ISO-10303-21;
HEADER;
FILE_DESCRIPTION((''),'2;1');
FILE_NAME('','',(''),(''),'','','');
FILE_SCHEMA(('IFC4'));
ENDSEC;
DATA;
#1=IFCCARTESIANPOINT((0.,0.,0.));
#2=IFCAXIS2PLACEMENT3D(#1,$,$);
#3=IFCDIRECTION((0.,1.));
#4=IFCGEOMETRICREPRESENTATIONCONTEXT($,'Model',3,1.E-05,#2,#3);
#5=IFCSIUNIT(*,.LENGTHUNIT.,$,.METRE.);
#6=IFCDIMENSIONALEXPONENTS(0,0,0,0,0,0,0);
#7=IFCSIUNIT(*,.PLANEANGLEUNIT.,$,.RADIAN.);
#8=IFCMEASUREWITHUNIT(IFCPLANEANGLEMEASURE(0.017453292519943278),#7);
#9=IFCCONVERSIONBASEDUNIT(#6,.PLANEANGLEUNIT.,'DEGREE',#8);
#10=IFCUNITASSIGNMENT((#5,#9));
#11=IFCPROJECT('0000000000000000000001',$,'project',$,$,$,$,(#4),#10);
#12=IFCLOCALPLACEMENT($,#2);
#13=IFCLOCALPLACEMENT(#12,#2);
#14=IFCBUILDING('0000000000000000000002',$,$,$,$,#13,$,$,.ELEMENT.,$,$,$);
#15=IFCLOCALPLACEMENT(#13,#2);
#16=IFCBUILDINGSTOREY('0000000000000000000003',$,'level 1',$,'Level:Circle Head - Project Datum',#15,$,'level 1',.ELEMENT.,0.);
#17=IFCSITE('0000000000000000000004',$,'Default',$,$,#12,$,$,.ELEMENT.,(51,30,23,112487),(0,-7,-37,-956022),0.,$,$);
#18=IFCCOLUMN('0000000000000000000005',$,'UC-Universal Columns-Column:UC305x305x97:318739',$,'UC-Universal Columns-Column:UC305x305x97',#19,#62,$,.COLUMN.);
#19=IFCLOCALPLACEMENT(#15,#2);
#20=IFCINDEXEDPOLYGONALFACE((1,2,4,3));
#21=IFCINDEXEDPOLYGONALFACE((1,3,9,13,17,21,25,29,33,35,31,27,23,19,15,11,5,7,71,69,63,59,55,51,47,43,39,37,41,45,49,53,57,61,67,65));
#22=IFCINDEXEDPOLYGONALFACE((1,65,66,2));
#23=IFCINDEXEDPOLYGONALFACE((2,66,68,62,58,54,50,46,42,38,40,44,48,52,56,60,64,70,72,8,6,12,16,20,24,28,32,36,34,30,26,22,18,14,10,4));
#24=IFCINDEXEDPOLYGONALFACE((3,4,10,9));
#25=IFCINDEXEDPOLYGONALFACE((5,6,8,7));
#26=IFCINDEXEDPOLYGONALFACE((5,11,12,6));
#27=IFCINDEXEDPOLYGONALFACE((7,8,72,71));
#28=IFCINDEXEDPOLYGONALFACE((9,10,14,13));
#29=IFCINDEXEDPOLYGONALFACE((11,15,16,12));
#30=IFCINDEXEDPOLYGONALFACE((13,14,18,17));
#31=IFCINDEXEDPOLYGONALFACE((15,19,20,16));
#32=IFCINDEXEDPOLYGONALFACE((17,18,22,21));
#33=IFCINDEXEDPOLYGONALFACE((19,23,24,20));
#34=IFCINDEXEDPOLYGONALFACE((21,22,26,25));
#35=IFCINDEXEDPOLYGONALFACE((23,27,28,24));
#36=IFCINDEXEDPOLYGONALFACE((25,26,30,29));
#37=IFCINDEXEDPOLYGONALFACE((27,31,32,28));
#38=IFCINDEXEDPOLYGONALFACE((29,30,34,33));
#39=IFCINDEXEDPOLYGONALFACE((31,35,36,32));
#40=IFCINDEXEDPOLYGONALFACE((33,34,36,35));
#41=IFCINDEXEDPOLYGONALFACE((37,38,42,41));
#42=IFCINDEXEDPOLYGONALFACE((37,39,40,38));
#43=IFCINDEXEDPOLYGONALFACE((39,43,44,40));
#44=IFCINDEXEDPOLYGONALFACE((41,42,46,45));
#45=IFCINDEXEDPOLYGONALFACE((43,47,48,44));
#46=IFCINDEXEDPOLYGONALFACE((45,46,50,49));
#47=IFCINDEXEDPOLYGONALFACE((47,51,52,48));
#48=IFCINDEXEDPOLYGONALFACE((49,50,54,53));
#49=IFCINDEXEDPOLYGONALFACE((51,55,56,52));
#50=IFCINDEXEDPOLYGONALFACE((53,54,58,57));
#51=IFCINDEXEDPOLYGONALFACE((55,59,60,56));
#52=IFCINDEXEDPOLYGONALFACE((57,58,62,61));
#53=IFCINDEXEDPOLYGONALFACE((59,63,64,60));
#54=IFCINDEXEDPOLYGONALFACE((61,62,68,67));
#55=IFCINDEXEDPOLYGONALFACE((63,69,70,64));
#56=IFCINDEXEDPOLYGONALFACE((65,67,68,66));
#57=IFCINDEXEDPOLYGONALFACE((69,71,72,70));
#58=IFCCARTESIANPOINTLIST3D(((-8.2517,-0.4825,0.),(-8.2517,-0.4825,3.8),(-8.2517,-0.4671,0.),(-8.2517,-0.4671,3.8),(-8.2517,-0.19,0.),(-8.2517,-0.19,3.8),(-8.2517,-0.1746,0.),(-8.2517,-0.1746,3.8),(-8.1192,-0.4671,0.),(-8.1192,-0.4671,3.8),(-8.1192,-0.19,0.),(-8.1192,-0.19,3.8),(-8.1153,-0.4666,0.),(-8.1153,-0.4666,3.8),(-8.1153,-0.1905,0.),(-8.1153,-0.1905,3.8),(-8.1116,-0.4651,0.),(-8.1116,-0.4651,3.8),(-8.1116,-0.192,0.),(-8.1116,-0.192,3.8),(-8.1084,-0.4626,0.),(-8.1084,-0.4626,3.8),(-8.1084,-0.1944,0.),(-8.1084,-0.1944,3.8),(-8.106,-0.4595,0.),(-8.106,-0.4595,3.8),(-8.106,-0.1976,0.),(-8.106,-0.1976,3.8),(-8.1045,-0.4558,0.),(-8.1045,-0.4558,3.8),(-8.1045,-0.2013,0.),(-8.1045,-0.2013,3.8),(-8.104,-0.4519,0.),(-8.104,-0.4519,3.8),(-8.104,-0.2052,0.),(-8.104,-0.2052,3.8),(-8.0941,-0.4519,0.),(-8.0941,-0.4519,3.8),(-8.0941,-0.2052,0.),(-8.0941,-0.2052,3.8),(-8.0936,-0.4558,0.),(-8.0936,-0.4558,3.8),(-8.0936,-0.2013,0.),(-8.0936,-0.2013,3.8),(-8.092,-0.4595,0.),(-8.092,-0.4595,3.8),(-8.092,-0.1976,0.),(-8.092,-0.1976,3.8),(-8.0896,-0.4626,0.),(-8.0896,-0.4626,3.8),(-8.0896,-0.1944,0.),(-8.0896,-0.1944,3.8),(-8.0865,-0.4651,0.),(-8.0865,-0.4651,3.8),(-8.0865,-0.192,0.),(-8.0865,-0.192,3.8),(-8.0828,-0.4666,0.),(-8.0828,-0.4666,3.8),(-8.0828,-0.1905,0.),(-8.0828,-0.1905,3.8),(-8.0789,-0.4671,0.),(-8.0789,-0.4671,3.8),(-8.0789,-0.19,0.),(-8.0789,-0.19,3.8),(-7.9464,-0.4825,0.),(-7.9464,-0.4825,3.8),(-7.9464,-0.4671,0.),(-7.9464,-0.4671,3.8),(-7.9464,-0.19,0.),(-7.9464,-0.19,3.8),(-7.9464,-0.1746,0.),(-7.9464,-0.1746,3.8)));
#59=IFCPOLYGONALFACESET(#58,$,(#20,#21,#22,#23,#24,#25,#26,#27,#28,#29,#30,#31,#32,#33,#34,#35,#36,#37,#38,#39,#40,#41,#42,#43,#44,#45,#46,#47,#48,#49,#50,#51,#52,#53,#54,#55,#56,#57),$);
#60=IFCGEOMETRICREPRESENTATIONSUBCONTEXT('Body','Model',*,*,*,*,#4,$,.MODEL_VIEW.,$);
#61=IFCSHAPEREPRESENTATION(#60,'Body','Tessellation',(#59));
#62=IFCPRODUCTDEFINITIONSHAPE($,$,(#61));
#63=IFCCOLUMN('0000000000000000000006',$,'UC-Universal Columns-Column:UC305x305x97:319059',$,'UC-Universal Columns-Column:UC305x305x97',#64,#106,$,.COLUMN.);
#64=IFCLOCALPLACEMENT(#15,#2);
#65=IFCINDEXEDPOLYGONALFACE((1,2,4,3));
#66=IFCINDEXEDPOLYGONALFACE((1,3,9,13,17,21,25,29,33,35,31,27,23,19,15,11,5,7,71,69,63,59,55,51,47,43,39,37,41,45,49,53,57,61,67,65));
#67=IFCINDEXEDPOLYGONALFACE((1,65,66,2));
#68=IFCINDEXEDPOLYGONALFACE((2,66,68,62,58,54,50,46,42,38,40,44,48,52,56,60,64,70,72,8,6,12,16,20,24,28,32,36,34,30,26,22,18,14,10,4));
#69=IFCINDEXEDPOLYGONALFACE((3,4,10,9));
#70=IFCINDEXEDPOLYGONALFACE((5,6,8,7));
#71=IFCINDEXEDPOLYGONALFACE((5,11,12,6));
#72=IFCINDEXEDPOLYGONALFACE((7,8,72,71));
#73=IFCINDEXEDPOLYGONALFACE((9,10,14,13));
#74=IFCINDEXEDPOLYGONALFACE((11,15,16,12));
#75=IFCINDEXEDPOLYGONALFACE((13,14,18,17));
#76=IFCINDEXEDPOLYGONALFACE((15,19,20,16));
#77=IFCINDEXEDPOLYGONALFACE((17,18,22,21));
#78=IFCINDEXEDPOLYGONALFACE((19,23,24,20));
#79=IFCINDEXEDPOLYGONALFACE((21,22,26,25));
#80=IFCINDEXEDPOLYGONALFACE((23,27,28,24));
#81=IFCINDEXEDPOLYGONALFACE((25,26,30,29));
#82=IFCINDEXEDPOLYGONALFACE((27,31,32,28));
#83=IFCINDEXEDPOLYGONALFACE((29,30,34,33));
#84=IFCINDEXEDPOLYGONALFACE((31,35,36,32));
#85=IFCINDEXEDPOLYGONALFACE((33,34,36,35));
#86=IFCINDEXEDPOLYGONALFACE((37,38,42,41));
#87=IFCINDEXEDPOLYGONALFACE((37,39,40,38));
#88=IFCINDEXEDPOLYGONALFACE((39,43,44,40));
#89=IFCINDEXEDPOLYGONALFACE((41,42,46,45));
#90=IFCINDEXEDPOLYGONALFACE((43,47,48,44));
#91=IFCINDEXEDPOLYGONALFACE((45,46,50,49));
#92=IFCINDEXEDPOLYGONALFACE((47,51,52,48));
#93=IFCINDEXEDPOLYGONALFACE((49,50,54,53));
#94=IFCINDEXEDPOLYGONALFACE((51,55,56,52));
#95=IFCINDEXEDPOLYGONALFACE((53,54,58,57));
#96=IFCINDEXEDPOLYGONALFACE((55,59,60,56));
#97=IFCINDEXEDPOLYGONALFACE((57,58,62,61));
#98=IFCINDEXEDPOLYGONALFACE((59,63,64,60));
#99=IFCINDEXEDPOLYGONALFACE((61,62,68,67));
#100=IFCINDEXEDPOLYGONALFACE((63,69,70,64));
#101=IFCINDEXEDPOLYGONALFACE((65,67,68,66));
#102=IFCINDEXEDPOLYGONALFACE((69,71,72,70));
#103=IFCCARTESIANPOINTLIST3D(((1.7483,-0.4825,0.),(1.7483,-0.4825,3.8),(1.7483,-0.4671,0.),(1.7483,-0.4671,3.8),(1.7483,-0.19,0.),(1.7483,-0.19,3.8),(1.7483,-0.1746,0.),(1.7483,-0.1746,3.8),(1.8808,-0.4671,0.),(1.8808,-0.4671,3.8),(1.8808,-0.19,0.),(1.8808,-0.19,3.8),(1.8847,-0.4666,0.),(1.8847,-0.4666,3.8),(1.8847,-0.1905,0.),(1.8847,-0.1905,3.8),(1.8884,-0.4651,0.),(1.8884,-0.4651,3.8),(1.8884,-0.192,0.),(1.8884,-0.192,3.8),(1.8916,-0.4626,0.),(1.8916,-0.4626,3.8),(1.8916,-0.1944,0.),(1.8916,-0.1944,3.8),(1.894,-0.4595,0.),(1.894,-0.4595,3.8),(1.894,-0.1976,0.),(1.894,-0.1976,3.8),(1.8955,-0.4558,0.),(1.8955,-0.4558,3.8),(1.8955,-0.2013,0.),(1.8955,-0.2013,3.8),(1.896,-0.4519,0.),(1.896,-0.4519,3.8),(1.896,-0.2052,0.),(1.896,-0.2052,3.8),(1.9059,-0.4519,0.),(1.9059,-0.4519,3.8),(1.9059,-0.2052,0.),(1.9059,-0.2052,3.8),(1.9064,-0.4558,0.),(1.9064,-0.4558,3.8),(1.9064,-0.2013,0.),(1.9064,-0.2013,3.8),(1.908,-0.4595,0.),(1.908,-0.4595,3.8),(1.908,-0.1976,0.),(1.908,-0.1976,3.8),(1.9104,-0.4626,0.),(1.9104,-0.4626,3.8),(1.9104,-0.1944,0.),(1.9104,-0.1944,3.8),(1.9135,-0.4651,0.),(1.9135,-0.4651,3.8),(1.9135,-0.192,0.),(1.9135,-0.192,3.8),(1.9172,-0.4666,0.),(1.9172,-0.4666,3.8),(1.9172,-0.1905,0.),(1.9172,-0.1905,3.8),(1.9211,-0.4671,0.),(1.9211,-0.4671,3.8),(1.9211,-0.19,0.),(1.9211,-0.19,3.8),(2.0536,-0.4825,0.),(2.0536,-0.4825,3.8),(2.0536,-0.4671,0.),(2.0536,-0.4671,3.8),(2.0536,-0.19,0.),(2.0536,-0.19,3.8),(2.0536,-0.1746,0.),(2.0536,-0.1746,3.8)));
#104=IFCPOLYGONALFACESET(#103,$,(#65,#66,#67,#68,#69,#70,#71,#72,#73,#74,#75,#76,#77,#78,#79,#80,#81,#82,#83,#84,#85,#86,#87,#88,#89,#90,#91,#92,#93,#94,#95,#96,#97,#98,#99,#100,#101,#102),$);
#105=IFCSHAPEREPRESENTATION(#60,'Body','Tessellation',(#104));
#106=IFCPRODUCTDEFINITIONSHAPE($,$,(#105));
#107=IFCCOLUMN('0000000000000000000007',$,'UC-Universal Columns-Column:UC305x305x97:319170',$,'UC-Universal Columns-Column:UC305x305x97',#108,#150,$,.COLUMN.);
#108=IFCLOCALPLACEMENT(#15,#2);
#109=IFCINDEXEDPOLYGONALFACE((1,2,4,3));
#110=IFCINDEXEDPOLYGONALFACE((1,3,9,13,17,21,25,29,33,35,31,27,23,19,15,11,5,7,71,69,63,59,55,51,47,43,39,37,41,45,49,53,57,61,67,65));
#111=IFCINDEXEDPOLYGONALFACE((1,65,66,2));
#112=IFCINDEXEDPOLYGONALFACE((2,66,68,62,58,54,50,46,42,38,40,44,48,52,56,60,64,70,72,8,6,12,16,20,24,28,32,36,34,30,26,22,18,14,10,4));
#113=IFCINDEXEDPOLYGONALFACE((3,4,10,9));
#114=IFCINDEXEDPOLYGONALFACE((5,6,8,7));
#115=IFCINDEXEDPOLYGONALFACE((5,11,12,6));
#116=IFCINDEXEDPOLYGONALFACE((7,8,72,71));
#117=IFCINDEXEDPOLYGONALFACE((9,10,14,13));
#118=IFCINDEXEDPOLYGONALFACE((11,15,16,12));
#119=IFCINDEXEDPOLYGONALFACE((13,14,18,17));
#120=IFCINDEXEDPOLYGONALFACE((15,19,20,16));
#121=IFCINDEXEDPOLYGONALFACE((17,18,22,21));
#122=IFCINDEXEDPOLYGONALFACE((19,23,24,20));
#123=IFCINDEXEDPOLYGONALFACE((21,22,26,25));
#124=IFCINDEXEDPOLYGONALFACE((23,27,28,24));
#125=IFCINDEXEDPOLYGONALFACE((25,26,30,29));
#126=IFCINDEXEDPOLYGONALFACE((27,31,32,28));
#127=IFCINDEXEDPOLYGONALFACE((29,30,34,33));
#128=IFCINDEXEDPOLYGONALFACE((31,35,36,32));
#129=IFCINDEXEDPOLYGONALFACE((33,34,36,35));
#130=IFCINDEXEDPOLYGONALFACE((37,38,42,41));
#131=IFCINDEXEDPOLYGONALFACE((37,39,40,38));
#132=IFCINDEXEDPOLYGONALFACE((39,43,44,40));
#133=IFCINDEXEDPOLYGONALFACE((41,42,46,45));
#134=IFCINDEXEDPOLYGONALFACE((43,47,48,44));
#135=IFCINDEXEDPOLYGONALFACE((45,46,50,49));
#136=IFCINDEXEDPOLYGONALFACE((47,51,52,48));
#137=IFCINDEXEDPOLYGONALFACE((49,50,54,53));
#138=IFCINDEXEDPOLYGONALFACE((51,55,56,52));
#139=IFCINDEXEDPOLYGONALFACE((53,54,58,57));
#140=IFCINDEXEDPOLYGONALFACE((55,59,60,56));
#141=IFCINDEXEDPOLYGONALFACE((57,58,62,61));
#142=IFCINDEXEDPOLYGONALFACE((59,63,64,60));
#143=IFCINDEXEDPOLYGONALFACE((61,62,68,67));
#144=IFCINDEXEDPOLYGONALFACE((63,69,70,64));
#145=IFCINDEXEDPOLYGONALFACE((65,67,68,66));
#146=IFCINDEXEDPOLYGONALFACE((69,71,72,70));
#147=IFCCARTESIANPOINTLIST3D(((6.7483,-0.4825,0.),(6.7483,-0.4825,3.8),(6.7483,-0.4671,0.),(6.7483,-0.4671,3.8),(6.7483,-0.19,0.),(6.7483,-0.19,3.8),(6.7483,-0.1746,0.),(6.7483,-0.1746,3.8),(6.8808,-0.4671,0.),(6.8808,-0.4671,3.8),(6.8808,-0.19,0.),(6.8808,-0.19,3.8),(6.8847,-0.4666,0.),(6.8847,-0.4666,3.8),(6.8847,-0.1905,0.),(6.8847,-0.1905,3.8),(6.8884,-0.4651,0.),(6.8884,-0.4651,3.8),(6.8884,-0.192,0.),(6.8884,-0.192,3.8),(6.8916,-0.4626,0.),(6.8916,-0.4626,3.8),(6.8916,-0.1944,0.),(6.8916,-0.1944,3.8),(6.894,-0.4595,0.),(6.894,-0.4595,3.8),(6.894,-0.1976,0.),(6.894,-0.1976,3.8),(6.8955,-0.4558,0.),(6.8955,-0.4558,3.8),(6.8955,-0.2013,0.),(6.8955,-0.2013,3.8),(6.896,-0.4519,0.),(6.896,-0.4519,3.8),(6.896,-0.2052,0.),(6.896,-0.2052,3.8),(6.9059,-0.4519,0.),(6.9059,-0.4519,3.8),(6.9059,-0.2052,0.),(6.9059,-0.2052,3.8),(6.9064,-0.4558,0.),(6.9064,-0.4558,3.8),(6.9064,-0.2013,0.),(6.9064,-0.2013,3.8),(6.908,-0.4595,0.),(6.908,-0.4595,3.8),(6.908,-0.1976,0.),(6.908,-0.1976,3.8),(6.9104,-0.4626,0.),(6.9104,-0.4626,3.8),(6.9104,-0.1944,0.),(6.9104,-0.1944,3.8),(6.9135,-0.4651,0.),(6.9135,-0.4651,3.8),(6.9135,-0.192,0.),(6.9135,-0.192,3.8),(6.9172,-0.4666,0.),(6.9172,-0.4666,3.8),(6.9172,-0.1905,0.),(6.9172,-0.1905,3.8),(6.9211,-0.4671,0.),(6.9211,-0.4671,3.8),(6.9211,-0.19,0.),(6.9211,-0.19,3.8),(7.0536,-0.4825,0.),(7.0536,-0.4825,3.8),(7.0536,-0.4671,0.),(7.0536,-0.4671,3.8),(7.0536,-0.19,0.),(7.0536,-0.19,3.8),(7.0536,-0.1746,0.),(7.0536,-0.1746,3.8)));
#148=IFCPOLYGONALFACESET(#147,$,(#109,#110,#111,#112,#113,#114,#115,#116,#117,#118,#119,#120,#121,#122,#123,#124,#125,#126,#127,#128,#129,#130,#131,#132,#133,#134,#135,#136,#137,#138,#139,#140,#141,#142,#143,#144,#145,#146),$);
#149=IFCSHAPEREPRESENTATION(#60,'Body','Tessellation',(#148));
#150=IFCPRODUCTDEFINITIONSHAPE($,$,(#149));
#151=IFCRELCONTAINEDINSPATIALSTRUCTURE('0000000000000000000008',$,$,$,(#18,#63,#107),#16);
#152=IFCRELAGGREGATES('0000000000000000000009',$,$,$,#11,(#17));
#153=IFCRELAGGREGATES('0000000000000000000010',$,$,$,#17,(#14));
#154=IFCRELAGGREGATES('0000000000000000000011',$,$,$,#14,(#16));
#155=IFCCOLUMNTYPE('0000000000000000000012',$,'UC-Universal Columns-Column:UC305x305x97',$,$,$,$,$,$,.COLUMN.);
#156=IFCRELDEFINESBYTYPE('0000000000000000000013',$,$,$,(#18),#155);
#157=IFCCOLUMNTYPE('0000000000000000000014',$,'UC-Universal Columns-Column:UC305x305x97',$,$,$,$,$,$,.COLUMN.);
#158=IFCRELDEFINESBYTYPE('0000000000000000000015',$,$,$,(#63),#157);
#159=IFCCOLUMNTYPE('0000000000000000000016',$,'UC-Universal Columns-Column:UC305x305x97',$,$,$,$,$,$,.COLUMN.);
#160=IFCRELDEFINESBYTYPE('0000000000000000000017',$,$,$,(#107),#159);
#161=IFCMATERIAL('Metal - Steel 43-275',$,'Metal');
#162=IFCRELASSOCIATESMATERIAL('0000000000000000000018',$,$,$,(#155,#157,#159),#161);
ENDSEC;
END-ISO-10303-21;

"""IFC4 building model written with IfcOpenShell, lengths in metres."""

from ifc_helpers import new_model, entity, si_unit, converted_unit, direction, frame, frame_2d, origin, origin_2d_with_axis, place, context, subcontext, project, spatial, i_section, extrude, source, transform, mapped, material, material_profile, profile_set, type_object, type_shapes, element, save


model = new_model("IFC4")

# Units and contexts
model_context = context("Model", 3, precision=1e-05, world=origin(), true_north=direction((0.0, 1.0)))
body_context = subcontext(model_context, "Body", "Model", "MODEL_VIEW")
ifc_project = project(units=[si_unit("LENGTHUNIT", "METRE"), converted_unit("PLANEANGLEUNIT", "DEGREE", entity("IfcPlaneAngleMeasure", 0.017453292519943278), si_unit("PLANEANGLEUNIT", "RADIAN"), dimensions=[0, 0, 0, 0, 0, 0, 0])], contexts=[model_context])

# Site, building, storey
site_placement = place(None, origin())
site = spatial("IfcSite", under=ifc_project, at=site_placement, Name="Default", CompositionType="ELEMENT", RefLatitude=(51, 30, 23, 112487), RefLongitude=(0, -7, -37, -956022), RefElevation=0.0)
building_placement = place(site_placement, origin())
building = spatial("IfcBuilding", under=site, at=building_placement, CompositionType="ELEMENT")
storey_placement = place(building_placement, origin())
storey = spatial("IfcBuildingStorey", under=building, at=storey_placement, Name="level 1", ObjectType="Level:Circle Head - Project Datum", LongName="level 1", CompositionType="ELEMENT", Elevation=0.0)

# Columns
ifc_material_1 = material(Name="Metal - Steel 43-275", Category="Metal")
ifc_material_profile = material_profile(ifc_material_1, i_section(OverallWidth=0.3053, OverallDepth=0.3079, WebThickness=0.0099, FlangeThickness=0.0154, FilletRadius=0.0152, at=frame_2d((0.0, 0.0), x_axis=(1.0, 0.0))), Name="UC305x305x97")
ifc_profile_set = profile_set([ifc_material_profile], Name="UC305x305x97")
column_type_1 = type_object("IfcColumnType", Name="UC-Universal Columns-Column:UC305x305x97", PredefinedType="COLUMN", material=ifc_profile_set)
shared_shape_1 = source(origin(), body_context, "Body", "SweptSolid", [
    extrude(i_section(OverallWidth=0.3053, OverallDepth=0.3079, WebThickness=0.0099, FlangeThickness=0.0154, FilletRadius=0.0152, at=origin_2d_with_axis()), frame((0.0, 0.0, 0.0), z_axis=(0.0, 0.0, 1.0), x_axis=(-1.0, 0.0, 0.0)), (0.0, 0.0, 1.0), 3.8),
])
type_shapes(column_type_1, [shared_shape_1])
column_1_placement = place(storey_placement, frame((-8.099, -0.3285, 0.0)))
element("IfcColumn", 1, at=column_1_placement, inside=storey, type_object=column_type_1, Name="UC-Universal Columns-Column:UC305x305x97:318739", ObjectType="UC-Universal Columns-Column:UC305x305x97", PredefinedType="COLUMN", context=body_context, shape_type="MappedRepresentation", body=[
    mapped(shared_shape_1, transform((0.0, 0.0, 0.0), scale=1.0)),
])
column_type_2 = type_object("IfcColumnType", Name="UC-Universal Columns-Column:UC305x305x97", PredefinedType="COLUMN", material=ifc_profile_set)
shared_shape_2 = source(origin(), body_context, "Body", "SweptSolid", [
    extrude(i_section(OverallWidth=0.3053, OverallDepth=0.3079, WebThickness=0.0099, FlangeThickness=0.0154, FilletRadius=0.0152, at=frame_2d((0.0, 0.0), x_axis=(1.0, 0.0))), frame((1.901, -0.3285, 0.0), z_axis=(0.0, 0.0, 1.0), x_axis=(-1.0, 0.0, 0.0)), (0.0, 0.0, 1.0), 3.8),
])
type_shapes(column_type_2, [shared_shape_2])
column_2_placement = place(storey_placement, origin())
element("IfcColumn", 2, at=column_2_placement, inside=storey, type_object=column_type_2, Name="UC-Universal Columns-Column:UC305x305x97:319059", ObjectType="UC-Universal Columns-Column:UC305x305x97", PredefinedType="COLUMN", context=body_context, shape_type="MappedRepresentation", body=[
    mapped(shared_shape_2, transform((0.0, 0.0, 0.0), scale=1.0)),
])
column_type_3 = type_object("IfcColumnType", Name="UC-Universal Columns-Column:UC305x305x97", PredefinedType="COLUMN", material=ifc_profile_set)
shared_shape_3 = source(origin(), body_context, "Body", "SweptSolid", [
    extrude(i_section(OverallWidth=0.3053, OverallDepth=0.3079, WebThickness=0.0099, FlangeThickness=0.0154, FilletRadius=0.0152, at=frame_2d((0.0, 0.0), x_axis=(1.0, 0.0))), frame((6.901, -0.3285, 0.0), z_axis=(0.0, 0.0, 1.0), x_axis=(-1.0, 0.0, 0.0)), (0.0, 0.0, 1.0), 3.8),
])
type_shapes(column_type_3, [shared_shape_3])
column_3_placement = place(storey_placement, origin())
element("IfcColumn", 3, at=column_3_placement, inside=storey, type_object=column_type_3, Name="UC-Universal Columns-Column:UC305x305x97:319170", ObjectType="UC-Universal Columns-Column:UC305x305x97", PredefinedType="COLUMN", context=body_context, shape_type="MappedRepresentation", body=[
    mapped(shared_shape_3, transform((0.0, 0.0, 0.0), scale=1.0)),
])

save(model, "model.ifc")
